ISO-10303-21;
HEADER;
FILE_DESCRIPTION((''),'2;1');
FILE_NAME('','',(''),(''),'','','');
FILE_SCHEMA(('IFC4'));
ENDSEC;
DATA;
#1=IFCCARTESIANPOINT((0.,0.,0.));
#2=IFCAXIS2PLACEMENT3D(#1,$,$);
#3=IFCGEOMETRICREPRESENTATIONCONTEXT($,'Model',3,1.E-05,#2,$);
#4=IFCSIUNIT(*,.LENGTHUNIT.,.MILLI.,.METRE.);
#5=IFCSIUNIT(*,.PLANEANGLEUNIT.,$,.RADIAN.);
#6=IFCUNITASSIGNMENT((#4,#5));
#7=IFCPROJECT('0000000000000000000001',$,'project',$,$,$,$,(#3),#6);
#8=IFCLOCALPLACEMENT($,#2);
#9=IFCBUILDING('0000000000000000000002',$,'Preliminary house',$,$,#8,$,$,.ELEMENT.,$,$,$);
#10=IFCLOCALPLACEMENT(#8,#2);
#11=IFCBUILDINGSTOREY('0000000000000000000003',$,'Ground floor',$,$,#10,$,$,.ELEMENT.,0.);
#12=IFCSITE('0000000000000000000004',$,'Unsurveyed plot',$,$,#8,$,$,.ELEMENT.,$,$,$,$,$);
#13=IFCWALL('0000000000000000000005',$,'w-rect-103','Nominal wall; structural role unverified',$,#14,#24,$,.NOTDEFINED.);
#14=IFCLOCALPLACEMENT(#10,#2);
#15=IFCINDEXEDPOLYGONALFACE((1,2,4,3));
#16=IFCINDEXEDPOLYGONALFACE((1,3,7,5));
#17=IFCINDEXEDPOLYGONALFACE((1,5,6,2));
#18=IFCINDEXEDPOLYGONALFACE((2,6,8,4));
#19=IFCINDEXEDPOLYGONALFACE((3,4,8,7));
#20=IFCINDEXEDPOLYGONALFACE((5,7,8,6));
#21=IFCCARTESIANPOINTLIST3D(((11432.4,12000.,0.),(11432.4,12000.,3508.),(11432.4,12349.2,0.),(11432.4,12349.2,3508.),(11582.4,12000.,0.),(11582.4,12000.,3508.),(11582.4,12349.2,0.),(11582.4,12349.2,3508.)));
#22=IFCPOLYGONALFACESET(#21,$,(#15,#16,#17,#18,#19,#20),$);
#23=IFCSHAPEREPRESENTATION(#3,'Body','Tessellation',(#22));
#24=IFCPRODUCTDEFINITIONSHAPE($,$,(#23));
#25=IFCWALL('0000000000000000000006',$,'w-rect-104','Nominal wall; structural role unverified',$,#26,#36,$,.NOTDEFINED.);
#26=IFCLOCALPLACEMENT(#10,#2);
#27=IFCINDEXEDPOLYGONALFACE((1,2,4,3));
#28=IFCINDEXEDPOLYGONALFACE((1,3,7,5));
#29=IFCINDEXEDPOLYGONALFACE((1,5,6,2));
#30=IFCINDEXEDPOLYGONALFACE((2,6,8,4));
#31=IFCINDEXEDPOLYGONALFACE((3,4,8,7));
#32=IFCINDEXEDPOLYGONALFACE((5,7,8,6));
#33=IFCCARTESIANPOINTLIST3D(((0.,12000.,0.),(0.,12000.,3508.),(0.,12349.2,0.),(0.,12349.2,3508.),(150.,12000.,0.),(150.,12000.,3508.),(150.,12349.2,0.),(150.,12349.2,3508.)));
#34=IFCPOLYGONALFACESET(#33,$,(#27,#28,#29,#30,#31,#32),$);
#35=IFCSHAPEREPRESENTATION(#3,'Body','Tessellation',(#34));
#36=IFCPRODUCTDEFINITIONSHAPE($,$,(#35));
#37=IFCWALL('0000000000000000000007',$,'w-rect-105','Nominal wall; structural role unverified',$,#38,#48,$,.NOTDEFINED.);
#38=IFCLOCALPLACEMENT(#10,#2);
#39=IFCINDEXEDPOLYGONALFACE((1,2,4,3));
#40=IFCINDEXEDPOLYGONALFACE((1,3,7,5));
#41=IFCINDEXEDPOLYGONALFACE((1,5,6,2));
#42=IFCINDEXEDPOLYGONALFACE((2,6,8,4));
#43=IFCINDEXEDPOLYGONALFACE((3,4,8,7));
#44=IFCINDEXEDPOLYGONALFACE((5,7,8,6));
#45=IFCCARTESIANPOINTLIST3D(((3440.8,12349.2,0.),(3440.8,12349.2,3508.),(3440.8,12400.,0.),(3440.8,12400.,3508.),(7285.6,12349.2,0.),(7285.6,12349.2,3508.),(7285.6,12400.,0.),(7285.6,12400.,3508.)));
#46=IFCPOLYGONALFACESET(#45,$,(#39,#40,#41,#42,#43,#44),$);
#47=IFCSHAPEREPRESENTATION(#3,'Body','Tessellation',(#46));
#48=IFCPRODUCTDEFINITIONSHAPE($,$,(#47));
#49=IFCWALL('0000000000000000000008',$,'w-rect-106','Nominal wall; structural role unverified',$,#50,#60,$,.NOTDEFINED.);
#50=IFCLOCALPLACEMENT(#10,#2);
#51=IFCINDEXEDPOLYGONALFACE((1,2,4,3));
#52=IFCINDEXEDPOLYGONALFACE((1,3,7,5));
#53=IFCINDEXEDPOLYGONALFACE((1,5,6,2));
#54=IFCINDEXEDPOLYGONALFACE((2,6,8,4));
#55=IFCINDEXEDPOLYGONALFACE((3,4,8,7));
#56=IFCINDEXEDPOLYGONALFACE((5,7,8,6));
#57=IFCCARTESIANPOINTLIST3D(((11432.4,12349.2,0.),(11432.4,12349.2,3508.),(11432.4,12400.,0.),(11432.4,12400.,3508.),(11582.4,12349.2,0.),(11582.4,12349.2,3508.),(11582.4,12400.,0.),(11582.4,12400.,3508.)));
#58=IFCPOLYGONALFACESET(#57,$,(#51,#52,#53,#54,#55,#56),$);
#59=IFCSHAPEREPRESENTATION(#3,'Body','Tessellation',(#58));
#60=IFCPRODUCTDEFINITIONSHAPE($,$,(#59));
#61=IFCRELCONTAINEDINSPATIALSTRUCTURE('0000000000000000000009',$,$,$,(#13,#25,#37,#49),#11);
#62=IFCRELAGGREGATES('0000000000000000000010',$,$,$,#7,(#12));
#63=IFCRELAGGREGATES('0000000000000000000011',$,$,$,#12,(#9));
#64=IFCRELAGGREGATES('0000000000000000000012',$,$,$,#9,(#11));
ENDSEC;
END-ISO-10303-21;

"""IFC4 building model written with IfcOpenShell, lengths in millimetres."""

from ifc_helpers import new_model, si_unit, origin, place, context, project, spatial, polyline, outline, extrude, element, save


model = new_model("IFC4")

# Units and contexts
model_context = context("Model", 3, precision=1e-05, world=origin())
ifc_project = project(units=[si_unit("LENGTHUNIT", "METRE", prefix="MILLI"), si_unit("PLANEANGLEUNIT", "RADIAN")], contexts=[model_context])

# Site, building, storey
placement_1 = place(None, origin())
site = spatial("IfcSite", under=ifc_project, at=placement_1, Name="Unsurveyed plot", CompositionType="ELEMENT")
building = spatial("IfcBuilding", under=site, at=placement_1, Name="Preliminary house", CompositionType="ELEMENT")
placement_2 = place(placement_1, origin())
storey = spatial("IfcBuildingStorey", under=building, at=placement_2, Name="Ground floor", CompositionType="ELEMENT", Elevation=0.0)

# Walls
element("IfcWall", 1, at=placement_2, inside=storey, Name="w-rect-103", Description="Nominal wall; structural role unverified", PredefinedType="NOTDEFINED", context=model_context, shape_type="SweptSolid", body=[
    extrude(outline(polyline([(11432.4, 12000.0), (11582.4, 12000.0), (11582.4, 12349.2), (11432.4, 12349.2), (11432.4, 12000.0)])), origin(), (0.0, 0.0, 1.0), 3508.0),
])
element("IfcWall", 2, at=placement_2, inside=storey, Name="w-rect-104", Description="Nominal wall; structural role unverified", PredefinedType="NOTDEFINED", context=model_context, shape_type="SweptSolid", body=[
    extrude(outline(polyline([(0.0, 12000.0), (150.0, 12000.0), (150.0, 12349.2), (0.0, 12349.2), (0.0, 12000.0)])), origin(), (0.0, 0.0, 1.0), 3508.0),
])
element("IfcWall", 3, at=placement_2, inside=storey, Name="w-rect-105", Description="Nominal wall; structural role unverified", PredefinedType="NOTDEFINED", context=model_context, shape_type="SweptSolid", body=[
    extrude(outline(polyline([(3440.8, 12349.2), (7285.6, 12349.2), (7285.6, 12400.0), (3440.8, 12400.0), (3440.8, 12349.2)])), origin(), (0.0, 0.0, 1.0), 3508.0),
])
element("IfcWall", 4, at=placement_2, inside=storey, Name="w-rect-106", Description="Nominal wall; structural role unverified", PredefinedType="NOTDEFINED", context=model_context, shape_type="SweptSolid", body=[
    extrude(outline(polyline([(11432.4, 12349.2), (11582.4, 12349.2), (11582.4, 12400.0), (11432.4, 12400.0), (11432.4, 12349.2)])), origin(), (0.0, 0.0, 1.0), 3508.0),
])

save(model, "model.ifc")
